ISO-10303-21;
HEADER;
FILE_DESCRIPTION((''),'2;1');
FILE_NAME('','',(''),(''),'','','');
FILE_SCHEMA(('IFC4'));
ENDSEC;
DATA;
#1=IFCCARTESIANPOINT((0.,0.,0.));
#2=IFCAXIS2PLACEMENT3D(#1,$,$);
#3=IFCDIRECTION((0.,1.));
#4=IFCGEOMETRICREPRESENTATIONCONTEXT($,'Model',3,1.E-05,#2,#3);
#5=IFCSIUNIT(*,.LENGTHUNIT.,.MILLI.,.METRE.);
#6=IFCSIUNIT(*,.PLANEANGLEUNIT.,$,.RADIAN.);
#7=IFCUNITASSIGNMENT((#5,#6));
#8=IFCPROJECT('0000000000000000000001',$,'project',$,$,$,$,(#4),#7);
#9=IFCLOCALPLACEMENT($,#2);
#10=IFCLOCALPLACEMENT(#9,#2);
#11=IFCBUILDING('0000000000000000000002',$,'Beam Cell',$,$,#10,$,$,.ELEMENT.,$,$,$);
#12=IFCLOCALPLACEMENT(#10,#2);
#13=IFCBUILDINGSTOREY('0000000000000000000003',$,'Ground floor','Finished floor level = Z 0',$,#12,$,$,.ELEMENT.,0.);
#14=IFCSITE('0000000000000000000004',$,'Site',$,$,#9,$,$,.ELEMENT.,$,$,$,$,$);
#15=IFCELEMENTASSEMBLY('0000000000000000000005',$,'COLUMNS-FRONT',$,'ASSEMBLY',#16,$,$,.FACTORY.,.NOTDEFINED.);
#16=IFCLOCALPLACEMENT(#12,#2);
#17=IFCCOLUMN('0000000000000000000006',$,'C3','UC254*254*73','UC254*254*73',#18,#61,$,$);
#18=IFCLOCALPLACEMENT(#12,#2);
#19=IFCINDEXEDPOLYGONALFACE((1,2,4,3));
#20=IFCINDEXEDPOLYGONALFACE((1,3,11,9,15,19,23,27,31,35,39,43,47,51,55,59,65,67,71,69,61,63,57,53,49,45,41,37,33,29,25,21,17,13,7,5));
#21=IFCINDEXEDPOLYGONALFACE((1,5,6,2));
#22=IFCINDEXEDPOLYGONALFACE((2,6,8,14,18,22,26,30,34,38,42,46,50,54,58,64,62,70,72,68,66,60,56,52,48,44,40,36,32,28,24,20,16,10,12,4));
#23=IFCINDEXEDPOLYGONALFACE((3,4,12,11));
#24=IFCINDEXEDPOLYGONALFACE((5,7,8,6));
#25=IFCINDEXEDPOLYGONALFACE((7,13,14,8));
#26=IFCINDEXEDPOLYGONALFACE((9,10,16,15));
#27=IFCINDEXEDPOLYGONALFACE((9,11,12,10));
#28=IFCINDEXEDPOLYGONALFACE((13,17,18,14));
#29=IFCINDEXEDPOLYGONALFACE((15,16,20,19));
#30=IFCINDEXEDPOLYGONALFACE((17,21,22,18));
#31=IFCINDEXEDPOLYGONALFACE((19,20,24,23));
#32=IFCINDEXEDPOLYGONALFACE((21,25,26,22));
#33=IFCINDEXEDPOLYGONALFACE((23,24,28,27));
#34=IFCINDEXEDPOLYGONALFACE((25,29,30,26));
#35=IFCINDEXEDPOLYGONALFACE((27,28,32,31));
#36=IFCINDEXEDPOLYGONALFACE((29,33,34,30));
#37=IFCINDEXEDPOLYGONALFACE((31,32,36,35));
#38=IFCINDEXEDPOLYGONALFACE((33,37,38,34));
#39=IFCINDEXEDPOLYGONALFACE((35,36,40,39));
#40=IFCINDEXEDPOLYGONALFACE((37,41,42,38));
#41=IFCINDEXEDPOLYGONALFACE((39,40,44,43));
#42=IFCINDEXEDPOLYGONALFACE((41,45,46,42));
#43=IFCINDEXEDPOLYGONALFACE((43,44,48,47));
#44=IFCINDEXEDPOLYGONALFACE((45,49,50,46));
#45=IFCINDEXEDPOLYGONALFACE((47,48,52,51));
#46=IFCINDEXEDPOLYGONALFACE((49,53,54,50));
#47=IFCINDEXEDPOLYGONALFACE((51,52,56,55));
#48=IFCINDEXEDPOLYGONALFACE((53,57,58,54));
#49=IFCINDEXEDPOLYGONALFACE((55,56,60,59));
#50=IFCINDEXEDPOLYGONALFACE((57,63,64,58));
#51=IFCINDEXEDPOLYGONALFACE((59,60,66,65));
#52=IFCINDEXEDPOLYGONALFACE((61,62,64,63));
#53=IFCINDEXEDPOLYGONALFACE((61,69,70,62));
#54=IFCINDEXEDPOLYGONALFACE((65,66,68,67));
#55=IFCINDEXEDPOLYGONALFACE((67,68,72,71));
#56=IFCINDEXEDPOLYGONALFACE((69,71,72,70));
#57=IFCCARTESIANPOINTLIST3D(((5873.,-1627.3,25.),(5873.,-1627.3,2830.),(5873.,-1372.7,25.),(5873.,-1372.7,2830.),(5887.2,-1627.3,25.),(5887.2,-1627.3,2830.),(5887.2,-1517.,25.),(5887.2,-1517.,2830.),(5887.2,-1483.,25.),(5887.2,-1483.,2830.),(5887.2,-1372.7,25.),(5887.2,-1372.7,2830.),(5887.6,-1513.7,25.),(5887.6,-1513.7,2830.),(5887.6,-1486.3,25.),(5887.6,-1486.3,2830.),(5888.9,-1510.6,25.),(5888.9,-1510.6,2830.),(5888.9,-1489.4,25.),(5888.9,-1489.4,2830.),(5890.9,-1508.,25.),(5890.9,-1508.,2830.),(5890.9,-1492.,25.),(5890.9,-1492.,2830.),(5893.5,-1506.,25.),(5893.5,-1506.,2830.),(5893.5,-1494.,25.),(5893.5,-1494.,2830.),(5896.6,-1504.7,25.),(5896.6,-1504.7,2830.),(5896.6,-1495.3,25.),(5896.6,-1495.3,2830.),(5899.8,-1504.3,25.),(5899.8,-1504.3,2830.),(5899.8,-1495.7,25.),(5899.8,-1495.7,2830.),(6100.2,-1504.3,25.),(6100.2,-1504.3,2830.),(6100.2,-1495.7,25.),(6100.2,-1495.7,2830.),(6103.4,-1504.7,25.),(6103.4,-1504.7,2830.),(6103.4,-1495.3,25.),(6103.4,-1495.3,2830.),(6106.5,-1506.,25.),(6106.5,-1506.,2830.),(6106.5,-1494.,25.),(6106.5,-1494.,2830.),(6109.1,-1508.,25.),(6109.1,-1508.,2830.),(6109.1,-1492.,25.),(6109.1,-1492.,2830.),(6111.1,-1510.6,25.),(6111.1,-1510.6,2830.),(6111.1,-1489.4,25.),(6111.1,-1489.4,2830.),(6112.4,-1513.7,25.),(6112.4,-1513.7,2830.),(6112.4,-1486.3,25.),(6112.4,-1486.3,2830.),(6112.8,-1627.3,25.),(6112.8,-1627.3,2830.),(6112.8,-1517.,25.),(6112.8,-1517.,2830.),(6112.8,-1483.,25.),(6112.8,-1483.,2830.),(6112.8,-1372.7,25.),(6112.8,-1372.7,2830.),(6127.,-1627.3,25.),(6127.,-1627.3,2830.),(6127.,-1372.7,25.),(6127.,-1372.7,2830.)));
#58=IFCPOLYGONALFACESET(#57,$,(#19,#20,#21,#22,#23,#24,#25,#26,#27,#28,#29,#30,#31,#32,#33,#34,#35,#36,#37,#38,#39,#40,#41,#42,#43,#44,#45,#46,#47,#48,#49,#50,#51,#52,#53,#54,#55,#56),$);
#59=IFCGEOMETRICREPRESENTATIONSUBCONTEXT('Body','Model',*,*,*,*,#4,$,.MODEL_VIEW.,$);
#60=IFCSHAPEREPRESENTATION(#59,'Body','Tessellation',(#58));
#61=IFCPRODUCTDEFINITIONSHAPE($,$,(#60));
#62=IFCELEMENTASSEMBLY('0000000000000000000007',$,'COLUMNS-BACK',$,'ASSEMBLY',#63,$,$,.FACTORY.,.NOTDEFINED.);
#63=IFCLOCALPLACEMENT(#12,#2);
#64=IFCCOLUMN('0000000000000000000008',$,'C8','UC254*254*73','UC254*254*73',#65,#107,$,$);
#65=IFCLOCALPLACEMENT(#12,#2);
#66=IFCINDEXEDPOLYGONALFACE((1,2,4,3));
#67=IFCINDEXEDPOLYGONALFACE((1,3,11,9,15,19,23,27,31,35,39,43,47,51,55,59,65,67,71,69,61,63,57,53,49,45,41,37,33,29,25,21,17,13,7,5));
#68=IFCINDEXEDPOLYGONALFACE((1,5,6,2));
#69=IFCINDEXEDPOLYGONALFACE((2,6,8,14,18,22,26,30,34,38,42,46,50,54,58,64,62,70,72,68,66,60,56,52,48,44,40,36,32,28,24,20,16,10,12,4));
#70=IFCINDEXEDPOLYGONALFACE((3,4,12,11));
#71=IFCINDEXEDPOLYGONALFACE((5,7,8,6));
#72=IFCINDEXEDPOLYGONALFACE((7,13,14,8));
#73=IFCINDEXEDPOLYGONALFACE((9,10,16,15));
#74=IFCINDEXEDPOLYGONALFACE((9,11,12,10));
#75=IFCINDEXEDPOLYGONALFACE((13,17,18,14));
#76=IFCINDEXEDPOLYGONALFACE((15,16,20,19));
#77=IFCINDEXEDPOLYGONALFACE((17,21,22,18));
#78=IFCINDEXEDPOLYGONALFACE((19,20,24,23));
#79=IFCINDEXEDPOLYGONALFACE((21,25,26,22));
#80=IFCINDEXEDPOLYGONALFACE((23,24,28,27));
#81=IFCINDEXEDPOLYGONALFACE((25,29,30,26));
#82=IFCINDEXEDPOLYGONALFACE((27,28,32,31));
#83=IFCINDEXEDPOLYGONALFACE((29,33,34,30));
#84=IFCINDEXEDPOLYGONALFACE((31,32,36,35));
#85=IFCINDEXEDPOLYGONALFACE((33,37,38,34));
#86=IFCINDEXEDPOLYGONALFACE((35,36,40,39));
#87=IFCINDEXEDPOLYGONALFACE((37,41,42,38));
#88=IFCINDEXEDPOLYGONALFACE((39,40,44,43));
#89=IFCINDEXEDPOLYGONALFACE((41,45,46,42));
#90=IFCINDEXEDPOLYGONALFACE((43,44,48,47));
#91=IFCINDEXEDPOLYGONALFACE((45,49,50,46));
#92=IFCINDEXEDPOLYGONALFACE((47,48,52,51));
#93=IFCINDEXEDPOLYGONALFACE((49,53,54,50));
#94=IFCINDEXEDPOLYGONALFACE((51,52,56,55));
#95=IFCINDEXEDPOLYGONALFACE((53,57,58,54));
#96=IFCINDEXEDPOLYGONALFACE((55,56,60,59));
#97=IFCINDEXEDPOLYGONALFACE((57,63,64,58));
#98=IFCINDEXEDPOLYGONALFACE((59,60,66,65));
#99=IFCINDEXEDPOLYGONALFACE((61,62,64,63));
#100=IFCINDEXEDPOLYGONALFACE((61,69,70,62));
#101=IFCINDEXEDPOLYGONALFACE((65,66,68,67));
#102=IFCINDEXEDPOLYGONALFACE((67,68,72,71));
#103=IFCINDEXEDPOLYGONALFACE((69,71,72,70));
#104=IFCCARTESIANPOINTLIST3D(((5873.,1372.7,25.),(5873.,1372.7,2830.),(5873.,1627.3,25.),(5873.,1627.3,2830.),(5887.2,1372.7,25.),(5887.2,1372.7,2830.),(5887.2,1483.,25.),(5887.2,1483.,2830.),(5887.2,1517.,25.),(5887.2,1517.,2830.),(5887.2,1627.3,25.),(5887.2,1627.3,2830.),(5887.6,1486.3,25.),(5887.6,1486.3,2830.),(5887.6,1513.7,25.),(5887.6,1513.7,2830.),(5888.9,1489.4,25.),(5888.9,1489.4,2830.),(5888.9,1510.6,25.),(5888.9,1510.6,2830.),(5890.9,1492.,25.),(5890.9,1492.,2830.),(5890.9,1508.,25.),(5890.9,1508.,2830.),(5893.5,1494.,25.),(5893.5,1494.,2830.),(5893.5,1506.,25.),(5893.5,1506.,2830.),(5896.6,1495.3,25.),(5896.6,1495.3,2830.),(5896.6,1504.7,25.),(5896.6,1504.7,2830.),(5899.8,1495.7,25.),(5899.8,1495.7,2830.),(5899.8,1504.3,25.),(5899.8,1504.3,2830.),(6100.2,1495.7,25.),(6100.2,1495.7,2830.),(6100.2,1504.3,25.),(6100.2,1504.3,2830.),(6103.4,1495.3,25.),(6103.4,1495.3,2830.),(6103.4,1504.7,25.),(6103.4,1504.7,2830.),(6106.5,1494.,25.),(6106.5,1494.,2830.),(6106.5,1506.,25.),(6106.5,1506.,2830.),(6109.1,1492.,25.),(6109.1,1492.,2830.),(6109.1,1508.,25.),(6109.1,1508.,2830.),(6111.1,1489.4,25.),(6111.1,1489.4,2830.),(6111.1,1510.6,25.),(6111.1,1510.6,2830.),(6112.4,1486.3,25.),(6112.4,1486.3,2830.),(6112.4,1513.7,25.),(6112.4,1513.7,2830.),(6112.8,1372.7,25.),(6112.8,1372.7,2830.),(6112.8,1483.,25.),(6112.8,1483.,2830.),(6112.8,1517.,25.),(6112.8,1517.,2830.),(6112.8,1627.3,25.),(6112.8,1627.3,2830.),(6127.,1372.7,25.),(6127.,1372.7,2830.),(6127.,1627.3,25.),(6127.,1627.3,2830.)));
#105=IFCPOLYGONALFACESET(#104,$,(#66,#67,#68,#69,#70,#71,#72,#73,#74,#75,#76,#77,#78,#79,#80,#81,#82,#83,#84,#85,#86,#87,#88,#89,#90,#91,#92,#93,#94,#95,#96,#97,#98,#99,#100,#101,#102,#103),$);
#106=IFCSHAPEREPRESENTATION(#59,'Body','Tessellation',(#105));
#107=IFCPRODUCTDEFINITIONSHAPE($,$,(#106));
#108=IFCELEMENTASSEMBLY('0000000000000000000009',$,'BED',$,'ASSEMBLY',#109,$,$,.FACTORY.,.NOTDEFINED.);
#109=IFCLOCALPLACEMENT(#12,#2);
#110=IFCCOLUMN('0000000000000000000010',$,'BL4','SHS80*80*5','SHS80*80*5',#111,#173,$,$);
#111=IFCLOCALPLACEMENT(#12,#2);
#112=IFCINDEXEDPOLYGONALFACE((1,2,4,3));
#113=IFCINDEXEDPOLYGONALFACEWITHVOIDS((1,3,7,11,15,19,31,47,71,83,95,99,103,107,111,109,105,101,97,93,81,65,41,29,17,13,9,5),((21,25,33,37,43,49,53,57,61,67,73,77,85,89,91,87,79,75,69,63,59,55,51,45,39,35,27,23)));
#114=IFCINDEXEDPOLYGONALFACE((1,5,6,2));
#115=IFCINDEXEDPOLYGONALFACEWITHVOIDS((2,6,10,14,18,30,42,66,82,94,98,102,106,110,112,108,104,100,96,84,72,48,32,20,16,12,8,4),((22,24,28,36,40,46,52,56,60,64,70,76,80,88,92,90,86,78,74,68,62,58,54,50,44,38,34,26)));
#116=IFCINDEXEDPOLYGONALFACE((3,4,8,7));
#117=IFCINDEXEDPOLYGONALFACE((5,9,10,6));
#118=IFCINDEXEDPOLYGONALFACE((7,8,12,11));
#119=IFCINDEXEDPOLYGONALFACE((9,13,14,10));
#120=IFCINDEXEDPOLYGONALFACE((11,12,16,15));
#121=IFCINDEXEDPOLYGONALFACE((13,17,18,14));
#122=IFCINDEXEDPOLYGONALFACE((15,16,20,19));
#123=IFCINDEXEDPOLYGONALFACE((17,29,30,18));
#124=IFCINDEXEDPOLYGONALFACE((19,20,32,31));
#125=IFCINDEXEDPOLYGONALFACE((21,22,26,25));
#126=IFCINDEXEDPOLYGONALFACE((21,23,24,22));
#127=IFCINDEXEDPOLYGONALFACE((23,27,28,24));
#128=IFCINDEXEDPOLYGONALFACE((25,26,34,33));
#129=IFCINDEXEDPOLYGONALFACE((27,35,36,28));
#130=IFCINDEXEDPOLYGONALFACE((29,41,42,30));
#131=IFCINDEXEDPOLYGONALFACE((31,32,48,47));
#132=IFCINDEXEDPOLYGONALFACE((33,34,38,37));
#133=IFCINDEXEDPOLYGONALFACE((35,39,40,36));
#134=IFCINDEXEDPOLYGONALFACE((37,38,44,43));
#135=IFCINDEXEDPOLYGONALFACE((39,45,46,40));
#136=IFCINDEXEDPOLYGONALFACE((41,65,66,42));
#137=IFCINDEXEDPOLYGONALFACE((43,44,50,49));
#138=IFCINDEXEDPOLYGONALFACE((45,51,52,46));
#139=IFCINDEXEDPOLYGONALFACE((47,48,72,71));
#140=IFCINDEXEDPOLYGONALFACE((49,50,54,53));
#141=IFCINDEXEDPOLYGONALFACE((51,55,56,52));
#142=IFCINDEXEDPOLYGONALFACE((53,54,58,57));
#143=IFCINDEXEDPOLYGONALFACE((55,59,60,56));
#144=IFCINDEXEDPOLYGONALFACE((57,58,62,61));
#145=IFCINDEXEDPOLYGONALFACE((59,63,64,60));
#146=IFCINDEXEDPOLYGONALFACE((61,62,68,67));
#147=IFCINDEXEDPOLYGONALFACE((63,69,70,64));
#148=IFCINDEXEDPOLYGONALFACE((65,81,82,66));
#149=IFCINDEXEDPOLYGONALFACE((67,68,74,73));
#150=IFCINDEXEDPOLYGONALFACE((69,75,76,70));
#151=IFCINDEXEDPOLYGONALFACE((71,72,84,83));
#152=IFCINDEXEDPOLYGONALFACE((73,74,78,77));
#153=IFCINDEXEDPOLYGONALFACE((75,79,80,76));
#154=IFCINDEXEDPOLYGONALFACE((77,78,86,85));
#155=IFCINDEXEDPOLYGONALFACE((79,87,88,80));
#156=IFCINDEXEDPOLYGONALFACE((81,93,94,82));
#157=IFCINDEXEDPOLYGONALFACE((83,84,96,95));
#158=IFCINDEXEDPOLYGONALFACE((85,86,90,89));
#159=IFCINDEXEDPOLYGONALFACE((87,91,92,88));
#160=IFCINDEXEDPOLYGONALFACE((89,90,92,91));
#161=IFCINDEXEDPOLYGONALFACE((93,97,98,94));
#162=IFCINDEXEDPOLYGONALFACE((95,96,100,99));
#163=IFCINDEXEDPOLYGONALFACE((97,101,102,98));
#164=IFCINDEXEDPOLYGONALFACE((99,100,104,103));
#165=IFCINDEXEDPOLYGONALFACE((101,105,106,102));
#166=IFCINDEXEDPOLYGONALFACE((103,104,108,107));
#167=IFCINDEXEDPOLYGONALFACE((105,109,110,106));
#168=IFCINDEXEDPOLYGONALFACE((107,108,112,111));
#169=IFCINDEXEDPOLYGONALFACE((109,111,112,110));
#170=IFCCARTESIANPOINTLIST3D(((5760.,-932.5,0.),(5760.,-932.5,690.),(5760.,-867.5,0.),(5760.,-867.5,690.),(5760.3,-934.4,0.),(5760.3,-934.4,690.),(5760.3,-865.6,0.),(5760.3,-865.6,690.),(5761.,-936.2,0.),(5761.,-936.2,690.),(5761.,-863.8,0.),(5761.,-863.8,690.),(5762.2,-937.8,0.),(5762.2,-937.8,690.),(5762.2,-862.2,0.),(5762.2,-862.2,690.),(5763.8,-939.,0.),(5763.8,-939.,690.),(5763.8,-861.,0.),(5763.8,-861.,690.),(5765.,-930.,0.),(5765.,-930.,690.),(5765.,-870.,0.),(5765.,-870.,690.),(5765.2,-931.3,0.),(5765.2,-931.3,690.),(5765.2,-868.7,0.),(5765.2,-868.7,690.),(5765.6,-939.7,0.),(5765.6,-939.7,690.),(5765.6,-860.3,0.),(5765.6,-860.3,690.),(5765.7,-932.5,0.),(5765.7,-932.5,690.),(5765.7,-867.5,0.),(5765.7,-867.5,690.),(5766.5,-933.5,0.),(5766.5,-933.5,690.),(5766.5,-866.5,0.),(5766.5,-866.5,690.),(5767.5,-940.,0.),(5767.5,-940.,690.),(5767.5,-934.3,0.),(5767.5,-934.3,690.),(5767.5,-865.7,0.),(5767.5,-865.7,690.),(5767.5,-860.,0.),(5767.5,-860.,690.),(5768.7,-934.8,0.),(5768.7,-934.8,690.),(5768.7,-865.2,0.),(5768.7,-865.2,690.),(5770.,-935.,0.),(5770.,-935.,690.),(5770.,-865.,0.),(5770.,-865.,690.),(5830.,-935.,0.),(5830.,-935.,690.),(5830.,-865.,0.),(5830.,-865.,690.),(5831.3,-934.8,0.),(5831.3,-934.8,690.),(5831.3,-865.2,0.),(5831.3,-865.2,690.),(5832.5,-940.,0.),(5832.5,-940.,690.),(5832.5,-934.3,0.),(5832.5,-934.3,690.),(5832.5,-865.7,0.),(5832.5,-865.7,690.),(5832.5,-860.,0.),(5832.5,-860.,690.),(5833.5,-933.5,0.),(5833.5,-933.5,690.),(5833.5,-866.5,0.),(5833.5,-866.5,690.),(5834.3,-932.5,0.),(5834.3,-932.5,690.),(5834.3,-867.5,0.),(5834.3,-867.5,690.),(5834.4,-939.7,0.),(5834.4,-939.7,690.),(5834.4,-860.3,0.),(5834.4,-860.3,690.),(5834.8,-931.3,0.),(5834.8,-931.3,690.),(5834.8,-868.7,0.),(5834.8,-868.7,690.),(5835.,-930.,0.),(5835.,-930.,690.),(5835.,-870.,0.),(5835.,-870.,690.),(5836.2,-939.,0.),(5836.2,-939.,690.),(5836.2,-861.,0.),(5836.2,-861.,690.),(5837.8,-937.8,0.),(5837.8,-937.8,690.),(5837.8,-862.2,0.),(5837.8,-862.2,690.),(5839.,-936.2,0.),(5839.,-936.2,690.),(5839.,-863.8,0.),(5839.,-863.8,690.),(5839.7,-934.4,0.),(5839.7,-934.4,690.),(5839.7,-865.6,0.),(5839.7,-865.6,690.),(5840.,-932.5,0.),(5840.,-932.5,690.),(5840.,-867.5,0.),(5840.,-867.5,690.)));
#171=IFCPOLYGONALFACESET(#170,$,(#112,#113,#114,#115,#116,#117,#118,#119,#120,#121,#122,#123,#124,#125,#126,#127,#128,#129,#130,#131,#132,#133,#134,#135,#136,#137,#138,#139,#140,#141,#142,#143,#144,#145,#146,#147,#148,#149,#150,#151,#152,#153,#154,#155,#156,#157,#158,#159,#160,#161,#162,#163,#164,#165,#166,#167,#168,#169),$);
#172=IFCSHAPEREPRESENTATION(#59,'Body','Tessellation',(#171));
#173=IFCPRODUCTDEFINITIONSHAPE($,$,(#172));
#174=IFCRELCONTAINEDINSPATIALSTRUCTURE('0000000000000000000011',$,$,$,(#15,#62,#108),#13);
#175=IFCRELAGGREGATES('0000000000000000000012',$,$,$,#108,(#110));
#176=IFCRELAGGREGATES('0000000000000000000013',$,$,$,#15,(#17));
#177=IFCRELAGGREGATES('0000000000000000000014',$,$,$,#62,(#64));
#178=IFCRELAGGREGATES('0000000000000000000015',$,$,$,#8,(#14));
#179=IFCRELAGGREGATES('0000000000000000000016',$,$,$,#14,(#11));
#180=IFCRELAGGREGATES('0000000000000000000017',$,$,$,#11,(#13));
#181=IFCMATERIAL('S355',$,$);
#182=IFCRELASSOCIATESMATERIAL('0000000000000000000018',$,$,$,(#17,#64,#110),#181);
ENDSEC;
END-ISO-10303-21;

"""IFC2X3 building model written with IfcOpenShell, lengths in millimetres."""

from ifc_helpers import new_model, si_unit, direction, frame, origin, origin_2d, place, context, subcontext, project, spatial, hollow_rectangle, i_section, extrude, material, element, aggregate, save


model = new_model("IFC2X3")

# Units and contexts
model_context = context("Model", 3, precision=1e-05, world=origin(), true_north=direction((0.0, 1.0)))
body_context = subcontext(model_context, "Body", "Model", "MODEL_VIEW")
ifc_project = project(units=[si_unit("LENGTHUNIT", "METRE", prefix="MILLI"), si_unit("PLANEANGLEUNIT", "RADIAN")], contexts=[model_context])

# Site, building, storey
site_placement = place(None, origin())
site = spatial("IfcSite", under=ifc_project, at=site_placement, Name="Site", CompositionType="ELEMENT")
building_placement = place(site_placement, origin())
building = spatial("IfcBuilding", under=site, at=building_placement, Name="Beam Cell", CompositionType="ELEMENT")
storey_placement = place(building_placement, origin())
storey = spatial("IfcBuildingStorey", under=building, at=storey_placement, Name="Ground floor", Description="Finished floor level = Z 0", CompositionType="ELEMENT", Elevation=0.0)

# Element assemblies, columns
assembly_1_placement = place(storey_placement, origin())
assembly_1 = element("IfcElementAssembly", 1, at=assembly_1_placement, inside=storey, Name="COLUMNS-FRONT", ObjectType="ASSEMBLY", AssemblyPlace="FACTORY", PredefinedType="NOTDEFINED")
ifc_material = material(Name="S355")
column_1_placement = place(storey_placement, frame((6000.0, -1500.0, 25.0), z_axis=(0.0, 0.0, 1.0), x_axis=(0.0, 1.0, 0.0)))
column_1 = element("IfcColumn", 2, at=column_1_placement, material=ifc_material, Name="C3", Description="UC254*254*73", ObjectType="UC254*254*73", context=body_context, shape_type="SweptSolid", body=[
    extrude(i_section(OverallWidth=254.6, OverallDepth=254.1, WebThickness=8.6, FlangeThickness=14.2, FilletRadius=12.7, at=origin_2d()), origin(), (0.0, 0.0, 1.0), 2805.0),
])
assembly_2_placement = place(storey_placement, origin())
assembly_2 = element("IfcElementAssembly", 3, at=assembly_2_placement, inside=storey, Name="COLUMNS-BACK", ObjectType="ASSEMBLY", AssemblyPlace="FACTORY", PredefinedType="NOTDEFINED")
column_2_placement = place(storey_placement, frame((6000.0, 1500.0, 25.0), z_axis=(0.0, 0.0, 1.0), x_axis=(0.0, 1.0, 0.0)))
column_2 = element("IfcColumn", 4, at=column_2_placement, material=ifc_material, Name="C8", Description="UC254*254*73", ObjectType="UC254*254*73", context=body_context, shape_type="SweptSolid", body=[
    extrude(i_section(OverallWidth=254.6, OverallDepth=254.1, WebThickness=8.6, FlangeThickness=14.2, FilletRadius=12.7, at=origin_2d()), origin(), (0.0, 0.0, 1.0), 2805.0),
])

# Element assembly, column
assembly_3_placement = place(storey_placement, origin())
assembly_3 = element("IfcElementAssembly", 5, at=assembly_3_placement, inside=storey, Name="BED", ObjectType="ASSEMBLY", AssemblyPlace="FACTORY", PredefinedType="NOTDEFINED")
column_3_placement = place(storey_placement, frame((5800.0, -900.0, 0.0), z_axis=(0.0, 0.0, 1.0), x_axis=(1.0, 0.0, 0.0)))
column_3 = element("IfcColumn", 6, at=column_3_placement, material=ifc_material, Name="BL4", Description="SHS80*80*5", ObjectType="SHS80*80*5", context=body_context, shape_type="SweptSolid", body=[
    extrude(hollow_rectangle(XDim=80.0, YDim=80.0, WallThickness=5.0, InnerFilletRadius=5.0, OuterFilletRadius=7.5, at=origin_2d()), origin(), (0.0, 0.0, 1.0), 690.0),
])

aggregate(assembly_3, [column_3])

aggregate(assembly_1, [column_1])
aggregate(assembly_2, [column_2])

save(model, "model.ifc")
